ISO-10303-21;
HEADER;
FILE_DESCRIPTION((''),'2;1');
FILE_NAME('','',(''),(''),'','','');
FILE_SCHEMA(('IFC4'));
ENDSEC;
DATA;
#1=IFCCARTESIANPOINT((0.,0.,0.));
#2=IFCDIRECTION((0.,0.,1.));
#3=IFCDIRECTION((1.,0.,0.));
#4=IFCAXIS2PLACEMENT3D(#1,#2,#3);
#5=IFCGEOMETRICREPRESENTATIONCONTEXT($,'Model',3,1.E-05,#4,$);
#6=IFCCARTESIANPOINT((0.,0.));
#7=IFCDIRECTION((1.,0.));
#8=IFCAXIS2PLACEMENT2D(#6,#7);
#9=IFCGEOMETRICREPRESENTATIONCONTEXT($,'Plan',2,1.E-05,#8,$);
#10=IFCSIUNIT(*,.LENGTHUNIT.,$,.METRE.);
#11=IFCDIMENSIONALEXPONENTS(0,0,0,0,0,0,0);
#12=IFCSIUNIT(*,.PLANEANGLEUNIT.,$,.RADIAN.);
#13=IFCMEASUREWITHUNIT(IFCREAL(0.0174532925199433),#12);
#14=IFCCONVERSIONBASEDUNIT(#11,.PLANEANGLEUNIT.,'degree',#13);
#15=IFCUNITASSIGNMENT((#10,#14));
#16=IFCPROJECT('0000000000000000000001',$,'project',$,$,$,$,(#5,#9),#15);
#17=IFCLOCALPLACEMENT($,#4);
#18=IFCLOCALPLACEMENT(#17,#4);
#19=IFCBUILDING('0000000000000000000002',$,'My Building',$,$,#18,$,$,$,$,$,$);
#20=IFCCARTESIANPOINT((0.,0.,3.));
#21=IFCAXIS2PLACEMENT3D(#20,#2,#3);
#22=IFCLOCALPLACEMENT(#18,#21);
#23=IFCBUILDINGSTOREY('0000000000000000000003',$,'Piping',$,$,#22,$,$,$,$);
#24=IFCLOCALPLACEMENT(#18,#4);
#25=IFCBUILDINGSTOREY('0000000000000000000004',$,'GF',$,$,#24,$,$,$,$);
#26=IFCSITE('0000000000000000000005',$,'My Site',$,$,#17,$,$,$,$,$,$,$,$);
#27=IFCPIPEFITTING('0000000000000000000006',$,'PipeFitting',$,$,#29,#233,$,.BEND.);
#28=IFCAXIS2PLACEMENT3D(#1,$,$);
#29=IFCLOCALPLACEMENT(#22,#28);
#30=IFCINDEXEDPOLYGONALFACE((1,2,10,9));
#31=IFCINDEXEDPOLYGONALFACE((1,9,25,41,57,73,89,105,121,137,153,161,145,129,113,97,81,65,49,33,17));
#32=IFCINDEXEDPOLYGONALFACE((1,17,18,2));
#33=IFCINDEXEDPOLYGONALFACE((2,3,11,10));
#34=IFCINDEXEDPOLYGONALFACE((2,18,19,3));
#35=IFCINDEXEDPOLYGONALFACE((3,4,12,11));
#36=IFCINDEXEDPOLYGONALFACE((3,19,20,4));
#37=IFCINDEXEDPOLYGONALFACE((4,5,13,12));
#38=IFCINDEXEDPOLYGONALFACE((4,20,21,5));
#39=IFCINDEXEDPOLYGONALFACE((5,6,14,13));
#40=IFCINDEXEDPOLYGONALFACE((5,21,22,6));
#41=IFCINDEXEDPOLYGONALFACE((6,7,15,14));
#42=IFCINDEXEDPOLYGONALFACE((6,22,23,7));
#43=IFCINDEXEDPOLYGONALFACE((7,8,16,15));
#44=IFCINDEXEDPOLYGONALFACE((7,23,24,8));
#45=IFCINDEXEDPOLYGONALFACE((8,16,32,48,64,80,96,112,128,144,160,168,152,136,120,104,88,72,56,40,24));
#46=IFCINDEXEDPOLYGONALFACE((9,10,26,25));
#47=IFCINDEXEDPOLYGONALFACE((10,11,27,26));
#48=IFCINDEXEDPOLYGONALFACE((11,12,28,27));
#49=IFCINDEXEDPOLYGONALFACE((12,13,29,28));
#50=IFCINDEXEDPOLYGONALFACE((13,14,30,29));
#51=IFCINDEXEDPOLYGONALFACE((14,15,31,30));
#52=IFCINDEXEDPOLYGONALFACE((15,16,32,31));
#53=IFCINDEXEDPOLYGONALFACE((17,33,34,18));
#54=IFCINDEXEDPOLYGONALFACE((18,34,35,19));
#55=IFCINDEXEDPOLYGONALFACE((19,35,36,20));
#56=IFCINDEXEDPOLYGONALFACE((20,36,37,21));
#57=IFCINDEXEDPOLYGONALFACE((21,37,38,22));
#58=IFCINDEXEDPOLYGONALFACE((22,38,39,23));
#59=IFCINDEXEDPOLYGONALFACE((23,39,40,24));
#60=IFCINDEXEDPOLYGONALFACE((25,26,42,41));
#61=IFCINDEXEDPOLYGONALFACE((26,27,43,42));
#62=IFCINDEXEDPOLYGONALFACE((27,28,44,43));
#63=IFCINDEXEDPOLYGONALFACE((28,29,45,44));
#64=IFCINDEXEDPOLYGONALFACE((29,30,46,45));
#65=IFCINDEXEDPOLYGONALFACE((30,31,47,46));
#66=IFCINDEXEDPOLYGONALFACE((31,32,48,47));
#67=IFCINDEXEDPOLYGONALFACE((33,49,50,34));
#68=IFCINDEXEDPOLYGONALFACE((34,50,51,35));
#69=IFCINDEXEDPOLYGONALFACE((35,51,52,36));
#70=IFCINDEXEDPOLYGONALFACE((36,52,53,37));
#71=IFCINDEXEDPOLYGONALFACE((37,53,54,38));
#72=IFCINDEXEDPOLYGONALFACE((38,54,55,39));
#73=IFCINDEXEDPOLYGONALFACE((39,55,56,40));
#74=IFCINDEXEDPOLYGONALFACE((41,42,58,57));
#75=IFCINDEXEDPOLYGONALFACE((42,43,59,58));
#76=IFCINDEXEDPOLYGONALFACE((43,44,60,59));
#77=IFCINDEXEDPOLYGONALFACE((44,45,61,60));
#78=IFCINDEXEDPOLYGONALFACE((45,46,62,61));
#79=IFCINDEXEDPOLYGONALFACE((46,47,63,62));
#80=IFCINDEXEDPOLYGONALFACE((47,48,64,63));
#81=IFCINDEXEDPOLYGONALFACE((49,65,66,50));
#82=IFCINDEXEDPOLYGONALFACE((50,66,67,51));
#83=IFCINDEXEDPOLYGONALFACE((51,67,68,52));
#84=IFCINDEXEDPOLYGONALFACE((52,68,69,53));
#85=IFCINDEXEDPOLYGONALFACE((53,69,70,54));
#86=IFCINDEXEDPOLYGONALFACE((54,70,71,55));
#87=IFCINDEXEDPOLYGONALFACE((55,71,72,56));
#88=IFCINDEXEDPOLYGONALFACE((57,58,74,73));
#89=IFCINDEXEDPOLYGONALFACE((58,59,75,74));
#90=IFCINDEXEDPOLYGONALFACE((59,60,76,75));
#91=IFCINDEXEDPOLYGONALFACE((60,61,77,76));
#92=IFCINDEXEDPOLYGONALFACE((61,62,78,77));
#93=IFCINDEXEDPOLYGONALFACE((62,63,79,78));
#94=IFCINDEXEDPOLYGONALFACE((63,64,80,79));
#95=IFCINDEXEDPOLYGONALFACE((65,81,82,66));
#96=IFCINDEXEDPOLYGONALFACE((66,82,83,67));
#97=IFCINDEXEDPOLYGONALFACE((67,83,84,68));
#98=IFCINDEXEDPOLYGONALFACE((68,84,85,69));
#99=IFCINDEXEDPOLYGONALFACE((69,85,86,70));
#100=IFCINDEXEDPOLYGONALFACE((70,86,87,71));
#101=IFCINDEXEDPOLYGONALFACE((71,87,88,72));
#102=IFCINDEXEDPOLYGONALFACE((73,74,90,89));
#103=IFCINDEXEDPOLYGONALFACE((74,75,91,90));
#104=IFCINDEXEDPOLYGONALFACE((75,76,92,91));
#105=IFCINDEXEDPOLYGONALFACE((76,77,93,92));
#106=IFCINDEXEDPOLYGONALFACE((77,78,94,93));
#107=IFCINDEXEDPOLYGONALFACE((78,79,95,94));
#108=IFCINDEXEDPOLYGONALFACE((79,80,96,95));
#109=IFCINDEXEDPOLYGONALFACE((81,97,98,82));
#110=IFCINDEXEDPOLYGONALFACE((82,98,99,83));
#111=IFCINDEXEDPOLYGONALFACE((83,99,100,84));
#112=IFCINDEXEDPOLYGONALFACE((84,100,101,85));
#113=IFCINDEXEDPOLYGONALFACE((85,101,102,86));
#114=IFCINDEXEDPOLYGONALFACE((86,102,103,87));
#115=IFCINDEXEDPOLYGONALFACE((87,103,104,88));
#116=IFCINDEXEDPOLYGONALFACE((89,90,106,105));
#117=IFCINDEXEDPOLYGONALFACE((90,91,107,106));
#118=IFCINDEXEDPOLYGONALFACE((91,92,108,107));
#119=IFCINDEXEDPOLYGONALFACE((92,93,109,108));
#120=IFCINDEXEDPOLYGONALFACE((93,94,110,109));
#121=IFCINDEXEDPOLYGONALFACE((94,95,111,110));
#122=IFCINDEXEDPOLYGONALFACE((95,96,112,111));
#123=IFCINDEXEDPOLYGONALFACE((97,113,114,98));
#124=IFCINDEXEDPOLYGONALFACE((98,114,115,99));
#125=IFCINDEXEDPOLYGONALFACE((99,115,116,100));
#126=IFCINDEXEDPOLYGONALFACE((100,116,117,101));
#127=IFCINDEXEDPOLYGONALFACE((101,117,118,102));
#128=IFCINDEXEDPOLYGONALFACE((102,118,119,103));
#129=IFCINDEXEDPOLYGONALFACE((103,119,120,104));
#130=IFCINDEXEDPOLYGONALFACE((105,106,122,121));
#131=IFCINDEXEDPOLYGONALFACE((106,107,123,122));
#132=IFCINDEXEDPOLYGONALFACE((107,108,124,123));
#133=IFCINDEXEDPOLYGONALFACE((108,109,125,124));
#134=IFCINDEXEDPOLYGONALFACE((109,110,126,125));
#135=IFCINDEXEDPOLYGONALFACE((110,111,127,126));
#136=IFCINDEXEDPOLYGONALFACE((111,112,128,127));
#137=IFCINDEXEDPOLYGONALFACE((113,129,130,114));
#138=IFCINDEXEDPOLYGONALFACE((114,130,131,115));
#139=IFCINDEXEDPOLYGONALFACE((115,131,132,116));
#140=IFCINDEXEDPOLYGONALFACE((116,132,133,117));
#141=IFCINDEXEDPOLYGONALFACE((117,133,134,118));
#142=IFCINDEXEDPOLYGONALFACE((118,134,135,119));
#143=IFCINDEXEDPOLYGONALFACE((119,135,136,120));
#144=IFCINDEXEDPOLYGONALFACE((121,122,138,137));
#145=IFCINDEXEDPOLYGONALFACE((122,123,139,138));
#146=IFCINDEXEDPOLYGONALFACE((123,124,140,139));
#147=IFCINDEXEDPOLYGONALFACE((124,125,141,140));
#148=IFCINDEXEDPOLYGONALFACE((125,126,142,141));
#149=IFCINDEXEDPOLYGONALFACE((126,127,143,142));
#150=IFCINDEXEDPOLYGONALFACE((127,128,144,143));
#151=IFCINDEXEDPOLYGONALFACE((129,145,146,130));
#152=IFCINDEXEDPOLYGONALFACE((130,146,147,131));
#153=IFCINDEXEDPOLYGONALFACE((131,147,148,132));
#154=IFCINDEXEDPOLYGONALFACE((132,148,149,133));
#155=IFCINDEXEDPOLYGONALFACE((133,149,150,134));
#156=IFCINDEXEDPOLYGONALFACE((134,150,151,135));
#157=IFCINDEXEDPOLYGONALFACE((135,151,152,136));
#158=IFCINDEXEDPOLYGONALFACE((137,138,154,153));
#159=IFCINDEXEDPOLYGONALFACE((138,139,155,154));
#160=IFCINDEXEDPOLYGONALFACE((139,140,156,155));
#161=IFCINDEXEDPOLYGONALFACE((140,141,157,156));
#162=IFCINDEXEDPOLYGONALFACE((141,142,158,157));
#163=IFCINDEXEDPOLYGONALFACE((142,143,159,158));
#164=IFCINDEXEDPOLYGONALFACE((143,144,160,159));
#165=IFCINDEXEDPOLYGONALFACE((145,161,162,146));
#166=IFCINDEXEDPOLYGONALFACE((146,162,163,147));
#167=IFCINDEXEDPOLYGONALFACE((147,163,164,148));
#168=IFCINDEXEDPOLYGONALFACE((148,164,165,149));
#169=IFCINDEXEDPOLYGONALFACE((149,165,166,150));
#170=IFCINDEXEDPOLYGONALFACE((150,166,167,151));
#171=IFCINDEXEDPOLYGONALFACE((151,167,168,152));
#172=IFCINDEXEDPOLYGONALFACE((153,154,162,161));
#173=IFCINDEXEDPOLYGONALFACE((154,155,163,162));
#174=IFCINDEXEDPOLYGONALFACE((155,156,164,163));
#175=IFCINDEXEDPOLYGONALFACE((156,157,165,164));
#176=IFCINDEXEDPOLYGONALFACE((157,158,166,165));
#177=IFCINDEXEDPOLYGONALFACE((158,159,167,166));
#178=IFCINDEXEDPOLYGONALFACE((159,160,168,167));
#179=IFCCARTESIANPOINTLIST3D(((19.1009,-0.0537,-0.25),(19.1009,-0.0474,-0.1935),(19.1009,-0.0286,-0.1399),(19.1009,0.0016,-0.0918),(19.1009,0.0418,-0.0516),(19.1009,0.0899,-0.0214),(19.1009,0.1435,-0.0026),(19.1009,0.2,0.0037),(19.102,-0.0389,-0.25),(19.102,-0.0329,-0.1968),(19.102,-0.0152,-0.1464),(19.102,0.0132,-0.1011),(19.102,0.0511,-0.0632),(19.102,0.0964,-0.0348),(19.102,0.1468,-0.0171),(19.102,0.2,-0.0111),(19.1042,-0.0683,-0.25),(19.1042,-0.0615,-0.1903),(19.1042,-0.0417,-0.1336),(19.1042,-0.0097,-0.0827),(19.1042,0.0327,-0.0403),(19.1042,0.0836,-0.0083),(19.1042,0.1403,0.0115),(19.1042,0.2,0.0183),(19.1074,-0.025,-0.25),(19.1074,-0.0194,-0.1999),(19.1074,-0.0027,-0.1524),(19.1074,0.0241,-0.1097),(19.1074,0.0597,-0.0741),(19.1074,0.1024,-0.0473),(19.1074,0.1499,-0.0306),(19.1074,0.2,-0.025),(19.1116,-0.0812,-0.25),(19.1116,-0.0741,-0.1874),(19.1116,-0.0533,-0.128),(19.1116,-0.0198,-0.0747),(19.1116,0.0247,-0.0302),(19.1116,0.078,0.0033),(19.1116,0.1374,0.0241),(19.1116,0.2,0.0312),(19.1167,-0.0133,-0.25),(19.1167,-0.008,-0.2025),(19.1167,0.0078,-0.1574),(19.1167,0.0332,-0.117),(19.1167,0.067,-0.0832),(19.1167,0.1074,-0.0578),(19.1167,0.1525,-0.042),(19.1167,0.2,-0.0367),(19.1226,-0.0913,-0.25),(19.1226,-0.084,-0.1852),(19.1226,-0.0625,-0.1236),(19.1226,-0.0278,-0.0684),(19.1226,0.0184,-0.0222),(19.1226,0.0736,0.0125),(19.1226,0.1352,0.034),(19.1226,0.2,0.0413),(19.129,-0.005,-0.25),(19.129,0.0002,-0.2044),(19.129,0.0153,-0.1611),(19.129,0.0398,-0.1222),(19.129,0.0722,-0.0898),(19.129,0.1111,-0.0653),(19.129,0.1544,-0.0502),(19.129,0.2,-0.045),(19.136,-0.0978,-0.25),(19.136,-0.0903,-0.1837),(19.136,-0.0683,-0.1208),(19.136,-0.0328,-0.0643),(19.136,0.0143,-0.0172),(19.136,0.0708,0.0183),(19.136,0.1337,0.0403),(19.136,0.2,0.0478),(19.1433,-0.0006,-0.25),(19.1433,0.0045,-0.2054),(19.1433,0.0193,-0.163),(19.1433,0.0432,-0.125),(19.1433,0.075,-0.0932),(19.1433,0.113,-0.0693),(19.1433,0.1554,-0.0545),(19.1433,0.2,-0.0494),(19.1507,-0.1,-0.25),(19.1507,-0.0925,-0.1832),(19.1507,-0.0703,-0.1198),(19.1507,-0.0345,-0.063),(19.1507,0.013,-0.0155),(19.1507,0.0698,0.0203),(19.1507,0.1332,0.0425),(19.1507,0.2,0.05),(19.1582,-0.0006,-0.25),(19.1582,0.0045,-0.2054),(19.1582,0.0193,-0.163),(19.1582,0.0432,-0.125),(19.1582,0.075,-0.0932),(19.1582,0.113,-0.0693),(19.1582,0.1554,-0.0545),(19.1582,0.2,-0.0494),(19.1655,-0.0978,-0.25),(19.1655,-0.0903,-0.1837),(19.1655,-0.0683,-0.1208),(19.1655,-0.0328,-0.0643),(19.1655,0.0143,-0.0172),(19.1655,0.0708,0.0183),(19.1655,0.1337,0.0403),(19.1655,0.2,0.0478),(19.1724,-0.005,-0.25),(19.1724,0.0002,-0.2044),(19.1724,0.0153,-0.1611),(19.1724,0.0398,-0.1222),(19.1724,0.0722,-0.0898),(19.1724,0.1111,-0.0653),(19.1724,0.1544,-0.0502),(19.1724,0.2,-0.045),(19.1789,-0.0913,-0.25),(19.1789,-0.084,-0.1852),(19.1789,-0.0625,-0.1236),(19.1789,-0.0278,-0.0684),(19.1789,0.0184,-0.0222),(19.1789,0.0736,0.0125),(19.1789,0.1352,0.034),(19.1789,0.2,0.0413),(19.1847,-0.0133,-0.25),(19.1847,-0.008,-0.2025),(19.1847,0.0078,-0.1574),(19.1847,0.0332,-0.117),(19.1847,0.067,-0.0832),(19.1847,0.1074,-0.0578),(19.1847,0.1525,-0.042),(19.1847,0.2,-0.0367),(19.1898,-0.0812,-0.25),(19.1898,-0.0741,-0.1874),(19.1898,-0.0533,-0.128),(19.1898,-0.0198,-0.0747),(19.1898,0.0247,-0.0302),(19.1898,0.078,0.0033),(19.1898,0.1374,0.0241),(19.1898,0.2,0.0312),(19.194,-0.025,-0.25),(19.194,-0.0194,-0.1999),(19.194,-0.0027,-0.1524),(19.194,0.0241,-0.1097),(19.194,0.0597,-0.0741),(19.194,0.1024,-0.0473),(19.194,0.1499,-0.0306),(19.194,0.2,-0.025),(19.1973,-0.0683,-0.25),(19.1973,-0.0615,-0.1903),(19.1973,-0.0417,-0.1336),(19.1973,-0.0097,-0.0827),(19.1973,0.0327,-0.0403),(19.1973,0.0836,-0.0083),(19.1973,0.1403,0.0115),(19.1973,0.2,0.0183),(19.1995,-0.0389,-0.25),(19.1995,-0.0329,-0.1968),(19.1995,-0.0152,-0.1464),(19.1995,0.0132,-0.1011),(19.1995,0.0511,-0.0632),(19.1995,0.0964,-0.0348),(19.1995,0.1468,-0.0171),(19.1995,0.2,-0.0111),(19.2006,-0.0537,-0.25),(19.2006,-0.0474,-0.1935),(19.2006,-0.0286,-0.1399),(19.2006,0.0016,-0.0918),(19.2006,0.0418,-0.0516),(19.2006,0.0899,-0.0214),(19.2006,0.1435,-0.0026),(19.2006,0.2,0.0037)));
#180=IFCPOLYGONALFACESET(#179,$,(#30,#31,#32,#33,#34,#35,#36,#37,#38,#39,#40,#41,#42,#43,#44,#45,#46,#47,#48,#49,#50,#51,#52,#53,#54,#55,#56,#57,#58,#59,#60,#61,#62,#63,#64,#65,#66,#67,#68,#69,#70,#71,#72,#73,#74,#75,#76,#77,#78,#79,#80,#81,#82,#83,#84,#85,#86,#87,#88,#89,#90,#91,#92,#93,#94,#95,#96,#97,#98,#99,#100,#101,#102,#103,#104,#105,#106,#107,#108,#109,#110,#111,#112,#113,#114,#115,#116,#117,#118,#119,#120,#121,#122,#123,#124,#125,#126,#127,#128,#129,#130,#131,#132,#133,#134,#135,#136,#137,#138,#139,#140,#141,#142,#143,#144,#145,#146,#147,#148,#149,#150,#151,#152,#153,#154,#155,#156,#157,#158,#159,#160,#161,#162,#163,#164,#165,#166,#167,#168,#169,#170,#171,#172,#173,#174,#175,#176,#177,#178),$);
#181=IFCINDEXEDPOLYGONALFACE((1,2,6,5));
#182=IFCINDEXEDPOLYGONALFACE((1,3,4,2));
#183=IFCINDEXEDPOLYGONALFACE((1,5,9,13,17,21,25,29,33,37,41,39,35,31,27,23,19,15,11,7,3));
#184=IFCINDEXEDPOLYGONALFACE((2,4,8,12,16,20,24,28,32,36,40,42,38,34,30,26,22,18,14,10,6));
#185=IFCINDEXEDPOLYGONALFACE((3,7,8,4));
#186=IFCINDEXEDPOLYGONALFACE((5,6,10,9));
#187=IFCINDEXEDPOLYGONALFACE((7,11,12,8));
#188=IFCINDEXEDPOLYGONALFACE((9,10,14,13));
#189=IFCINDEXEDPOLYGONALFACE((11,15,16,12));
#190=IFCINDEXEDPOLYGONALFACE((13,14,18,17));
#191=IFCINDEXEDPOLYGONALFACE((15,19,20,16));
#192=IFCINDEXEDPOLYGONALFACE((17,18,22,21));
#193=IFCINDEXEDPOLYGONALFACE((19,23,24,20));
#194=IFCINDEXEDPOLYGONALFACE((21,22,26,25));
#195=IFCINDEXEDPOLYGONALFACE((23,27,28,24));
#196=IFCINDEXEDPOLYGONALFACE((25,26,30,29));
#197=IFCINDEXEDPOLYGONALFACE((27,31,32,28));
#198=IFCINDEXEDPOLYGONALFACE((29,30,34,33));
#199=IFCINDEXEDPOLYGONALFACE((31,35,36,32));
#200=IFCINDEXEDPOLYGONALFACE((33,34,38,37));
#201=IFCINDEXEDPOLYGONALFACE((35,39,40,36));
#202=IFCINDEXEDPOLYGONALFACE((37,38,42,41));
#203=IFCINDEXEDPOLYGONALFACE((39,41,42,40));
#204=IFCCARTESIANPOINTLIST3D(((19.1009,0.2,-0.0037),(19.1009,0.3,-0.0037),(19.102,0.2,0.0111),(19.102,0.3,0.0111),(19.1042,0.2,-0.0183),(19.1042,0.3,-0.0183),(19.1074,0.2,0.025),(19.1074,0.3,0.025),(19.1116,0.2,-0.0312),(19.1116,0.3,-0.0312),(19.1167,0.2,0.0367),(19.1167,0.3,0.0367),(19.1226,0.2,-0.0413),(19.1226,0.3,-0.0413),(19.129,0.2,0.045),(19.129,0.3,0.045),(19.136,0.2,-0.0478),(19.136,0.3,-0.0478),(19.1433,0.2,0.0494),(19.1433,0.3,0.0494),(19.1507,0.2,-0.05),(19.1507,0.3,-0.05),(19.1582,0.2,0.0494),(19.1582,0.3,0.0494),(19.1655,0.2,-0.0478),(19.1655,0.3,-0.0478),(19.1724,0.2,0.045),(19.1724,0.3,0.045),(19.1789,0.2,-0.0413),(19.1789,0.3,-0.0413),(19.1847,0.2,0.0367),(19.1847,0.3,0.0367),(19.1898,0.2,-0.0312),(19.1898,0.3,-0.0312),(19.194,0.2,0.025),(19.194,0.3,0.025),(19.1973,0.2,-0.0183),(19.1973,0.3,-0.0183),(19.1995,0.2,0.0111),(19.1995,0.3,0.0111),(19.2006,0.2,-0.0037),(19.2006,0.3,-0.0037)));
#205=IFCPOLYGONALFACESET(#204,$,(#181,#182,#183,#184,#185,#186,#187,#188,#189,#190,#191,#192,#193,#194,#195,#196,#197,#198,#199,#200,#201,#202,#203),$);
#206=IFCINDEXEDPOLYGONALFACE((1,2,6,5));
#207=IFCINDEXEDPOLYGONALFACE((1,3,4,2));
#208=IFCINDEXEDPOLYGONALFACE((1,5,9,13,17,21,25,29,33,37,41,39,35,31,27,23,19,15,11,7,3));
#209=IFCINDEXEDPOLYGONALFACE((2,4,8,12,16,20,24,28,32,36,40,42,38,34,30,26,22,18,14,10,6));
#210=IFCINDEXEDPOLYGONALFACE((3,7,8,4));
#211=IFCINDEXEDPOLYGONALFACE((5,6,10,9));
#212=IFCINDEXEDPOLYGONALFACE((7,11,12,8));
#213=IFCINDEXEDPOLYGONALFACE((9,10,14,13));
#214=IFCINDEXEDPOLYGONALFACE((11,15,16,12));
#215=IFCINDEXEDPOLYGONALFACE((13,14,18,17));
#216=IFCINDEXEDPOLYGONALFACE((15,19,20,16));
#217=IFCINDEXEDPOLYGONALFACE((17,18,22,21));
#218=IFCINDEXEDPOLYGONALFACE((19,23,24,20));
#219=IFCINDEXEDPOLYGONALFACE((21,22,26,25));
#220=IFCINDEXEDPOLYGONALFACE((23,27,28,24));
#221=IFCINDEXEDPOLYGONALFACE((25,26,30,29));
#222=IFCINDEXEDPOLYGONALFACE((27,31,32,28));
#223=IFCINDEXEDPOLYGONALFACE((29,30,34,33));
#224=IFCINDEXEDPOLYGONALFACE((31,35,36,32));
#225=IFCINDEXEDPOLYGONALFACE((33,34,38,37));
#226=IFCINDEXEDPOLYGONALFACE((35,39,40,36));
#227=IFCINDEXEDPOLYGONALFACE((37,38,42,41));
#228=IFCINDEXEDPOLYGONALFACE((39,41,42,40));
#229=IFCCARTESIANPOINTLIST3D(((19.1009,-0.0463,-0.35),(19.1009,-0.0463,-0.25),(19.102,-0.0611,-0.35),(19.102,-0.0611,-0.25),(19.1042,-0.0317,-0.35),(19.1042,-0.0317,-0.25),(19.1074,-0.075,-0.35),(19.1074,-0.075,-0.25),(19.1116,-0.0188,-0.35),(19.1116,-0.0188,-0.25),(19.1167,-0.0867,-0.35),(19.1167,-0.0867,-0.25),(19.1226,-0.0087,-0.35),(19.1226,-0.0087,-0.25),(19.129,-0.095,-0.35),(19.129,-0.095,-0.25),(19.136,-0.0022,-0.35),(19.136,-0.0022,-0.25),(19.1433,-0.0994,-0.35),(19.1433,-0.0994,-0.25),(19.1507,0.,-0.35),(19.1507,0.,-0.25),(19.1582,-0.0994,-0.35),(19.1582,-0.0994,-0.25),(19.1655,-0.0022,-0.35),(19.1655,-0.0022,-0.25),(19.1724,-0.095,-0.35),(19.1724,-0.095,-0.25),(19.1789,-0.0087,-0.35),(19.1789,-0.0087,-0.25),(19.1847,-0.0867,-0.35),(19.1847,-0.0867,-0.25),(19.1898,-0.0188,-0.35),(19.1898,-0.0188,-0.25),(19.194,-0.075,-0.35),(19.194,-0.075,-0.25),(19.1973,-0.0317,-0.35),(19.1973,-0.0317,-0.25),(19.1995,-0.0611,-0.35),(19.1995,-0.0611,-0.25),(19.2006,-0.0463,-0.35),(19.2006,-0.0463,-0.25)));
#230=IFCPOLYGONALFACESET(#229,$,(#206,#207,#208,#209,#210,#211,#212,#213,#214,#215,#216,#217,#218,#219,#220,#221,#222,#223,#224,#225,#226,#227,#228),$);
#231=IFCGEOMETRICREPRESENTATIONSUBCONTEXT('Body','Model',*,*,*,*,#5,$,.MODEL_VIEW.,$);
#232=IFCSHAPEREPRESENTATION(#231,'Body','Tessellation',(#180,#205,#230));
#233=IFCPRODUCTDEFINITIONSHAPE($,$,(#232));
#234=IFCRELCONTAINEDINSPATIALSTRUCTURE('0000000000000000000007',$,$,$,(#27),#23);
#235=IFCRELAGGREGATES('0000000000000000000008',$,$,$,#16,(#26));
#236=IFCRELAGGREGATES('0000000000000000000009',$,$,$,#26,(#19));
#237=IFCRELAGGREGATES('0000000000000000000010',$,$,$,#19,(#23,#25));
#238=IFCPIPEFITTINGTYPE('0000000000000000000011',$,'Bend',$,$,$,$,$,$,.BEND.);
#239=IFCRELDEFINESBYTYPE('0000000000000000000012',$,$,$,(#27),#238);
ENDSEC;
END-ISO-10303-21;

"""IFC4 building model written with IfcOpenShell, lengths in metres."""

from ifc_helpers import new_model, entity, si_unit, converted_unit, frame, origin_with_axes, origin_2d_with_axis, place, context, subcontext, project, spatial, circle, extrude, source, transform, mapped, type_object, type_shapes, element, save


model = new_model("IFC4")

# Units and contexts
model_context = context("Model", 3, precision=1e-05, world=origin_with_axes())
plan_context = context("Plan", 2, precision=1e-05, world=origin_2d_with_axis())
body_context_1 = subcontext(model_context, "Body", "Model", "MODEL_VIEW")
ifc_project = project(units=[si_unit("LENGTHUNIT", "METRE"), converted_unit("PLANEANGLEUNIT", "degree", entity("IfcReal", 0.0174532925199433), si_unit("PLANEANGLEUNIT", "RADIAN"), dimensions=[0, 0, 0, 0, 0, 0, 0])], contexts=[model_context, plan_context])

# Site, building, storey
site_placement = place(None, origin_with_axes())
site = spatial("IfcSite", under=ifc_project, at=site_placement, Name="My Site")
building_placement = place(site_placement, origin_with_axes())
building = spatial("IfcBuilding", under=site, at=building_placement, Name="My Building")
storey_1_placement = place(building_placement, frame((0.0, 0.0, 3.0), z_axis=(0.0, 0.0, 1.0), x_axis=(1.0, 0.0, 0.0)))
storey_1 = spatial("IfcBuildingStorey", under=building, at=storey_1_placement, Name="Piping")

# Shared definitions
storey_2_placement = place(building_placement, origin_with_axes())
storey_2 = spatial("IfcBuildingStorey", under=building, at=storey_2_placement, Name="GF")

# Pipe fitting
pipe_fitting_type_1 = type_object("IfcPipeFittingType", Name="Bend", PredefinedType="BEND")
shared_shape_1 = source(origin_with_axes(), body_context_1, "Body", "SolidModel", [
    entity("IfcSweptDiskSolid", entity("IfcIndexedPolyCurve", entity("IfcCartesianPointList3D", [[0.0, 0.0, -0.1], [0.0732, 0.0, -0.2768], [0.25, 0.0, -0.35]]), [entity("IfcArcIndex", [1, 2, 3])]), 0.05),
    extrude(circle(Radius=0.05), origin_with_axes(), (0.0, 0.0, -1.0), 0.1),
    extrude(circle(Radius=0.05), frame((0.25, 0.0, -0.35), z_axis=(1.0, 0.0, 0.0), x_axis=(0.0, 0.0, 1.0)), (0.0, 0.0, 1.0), 0.1),
])
type_shapes(pipe_fitting_type_1, [shared_shape_1])
for number, where, z_axis, x_axis, name in (
    (1, (19.1507, 0.3, 0.0), (0.0, 1.0, 0.0), (0.0, 0.0, -1.0), "PipeFitting"),
):
    element("IfcPipeFitting", number, at=place(storey_1_placement, frame(where, z_axis=z_axis, x_axis=x_axis)), inside=storey_1, type_object=pipe_fitting_type_1, Name=name, PredefinedType="BEND", context=body_context_1, shape_type="MappedRepresentation", body=[
        mapped(shared_shape_1, transform((0.0, 0.0, 0.0), x_axis=(1.0, 0.0, 0.0), y_axis=(0.0, 1.0, 0.0), z_axis=(0.0, 0.0, 1.0), scale=1.0)),
    ])

save(model, "model.ifc")
